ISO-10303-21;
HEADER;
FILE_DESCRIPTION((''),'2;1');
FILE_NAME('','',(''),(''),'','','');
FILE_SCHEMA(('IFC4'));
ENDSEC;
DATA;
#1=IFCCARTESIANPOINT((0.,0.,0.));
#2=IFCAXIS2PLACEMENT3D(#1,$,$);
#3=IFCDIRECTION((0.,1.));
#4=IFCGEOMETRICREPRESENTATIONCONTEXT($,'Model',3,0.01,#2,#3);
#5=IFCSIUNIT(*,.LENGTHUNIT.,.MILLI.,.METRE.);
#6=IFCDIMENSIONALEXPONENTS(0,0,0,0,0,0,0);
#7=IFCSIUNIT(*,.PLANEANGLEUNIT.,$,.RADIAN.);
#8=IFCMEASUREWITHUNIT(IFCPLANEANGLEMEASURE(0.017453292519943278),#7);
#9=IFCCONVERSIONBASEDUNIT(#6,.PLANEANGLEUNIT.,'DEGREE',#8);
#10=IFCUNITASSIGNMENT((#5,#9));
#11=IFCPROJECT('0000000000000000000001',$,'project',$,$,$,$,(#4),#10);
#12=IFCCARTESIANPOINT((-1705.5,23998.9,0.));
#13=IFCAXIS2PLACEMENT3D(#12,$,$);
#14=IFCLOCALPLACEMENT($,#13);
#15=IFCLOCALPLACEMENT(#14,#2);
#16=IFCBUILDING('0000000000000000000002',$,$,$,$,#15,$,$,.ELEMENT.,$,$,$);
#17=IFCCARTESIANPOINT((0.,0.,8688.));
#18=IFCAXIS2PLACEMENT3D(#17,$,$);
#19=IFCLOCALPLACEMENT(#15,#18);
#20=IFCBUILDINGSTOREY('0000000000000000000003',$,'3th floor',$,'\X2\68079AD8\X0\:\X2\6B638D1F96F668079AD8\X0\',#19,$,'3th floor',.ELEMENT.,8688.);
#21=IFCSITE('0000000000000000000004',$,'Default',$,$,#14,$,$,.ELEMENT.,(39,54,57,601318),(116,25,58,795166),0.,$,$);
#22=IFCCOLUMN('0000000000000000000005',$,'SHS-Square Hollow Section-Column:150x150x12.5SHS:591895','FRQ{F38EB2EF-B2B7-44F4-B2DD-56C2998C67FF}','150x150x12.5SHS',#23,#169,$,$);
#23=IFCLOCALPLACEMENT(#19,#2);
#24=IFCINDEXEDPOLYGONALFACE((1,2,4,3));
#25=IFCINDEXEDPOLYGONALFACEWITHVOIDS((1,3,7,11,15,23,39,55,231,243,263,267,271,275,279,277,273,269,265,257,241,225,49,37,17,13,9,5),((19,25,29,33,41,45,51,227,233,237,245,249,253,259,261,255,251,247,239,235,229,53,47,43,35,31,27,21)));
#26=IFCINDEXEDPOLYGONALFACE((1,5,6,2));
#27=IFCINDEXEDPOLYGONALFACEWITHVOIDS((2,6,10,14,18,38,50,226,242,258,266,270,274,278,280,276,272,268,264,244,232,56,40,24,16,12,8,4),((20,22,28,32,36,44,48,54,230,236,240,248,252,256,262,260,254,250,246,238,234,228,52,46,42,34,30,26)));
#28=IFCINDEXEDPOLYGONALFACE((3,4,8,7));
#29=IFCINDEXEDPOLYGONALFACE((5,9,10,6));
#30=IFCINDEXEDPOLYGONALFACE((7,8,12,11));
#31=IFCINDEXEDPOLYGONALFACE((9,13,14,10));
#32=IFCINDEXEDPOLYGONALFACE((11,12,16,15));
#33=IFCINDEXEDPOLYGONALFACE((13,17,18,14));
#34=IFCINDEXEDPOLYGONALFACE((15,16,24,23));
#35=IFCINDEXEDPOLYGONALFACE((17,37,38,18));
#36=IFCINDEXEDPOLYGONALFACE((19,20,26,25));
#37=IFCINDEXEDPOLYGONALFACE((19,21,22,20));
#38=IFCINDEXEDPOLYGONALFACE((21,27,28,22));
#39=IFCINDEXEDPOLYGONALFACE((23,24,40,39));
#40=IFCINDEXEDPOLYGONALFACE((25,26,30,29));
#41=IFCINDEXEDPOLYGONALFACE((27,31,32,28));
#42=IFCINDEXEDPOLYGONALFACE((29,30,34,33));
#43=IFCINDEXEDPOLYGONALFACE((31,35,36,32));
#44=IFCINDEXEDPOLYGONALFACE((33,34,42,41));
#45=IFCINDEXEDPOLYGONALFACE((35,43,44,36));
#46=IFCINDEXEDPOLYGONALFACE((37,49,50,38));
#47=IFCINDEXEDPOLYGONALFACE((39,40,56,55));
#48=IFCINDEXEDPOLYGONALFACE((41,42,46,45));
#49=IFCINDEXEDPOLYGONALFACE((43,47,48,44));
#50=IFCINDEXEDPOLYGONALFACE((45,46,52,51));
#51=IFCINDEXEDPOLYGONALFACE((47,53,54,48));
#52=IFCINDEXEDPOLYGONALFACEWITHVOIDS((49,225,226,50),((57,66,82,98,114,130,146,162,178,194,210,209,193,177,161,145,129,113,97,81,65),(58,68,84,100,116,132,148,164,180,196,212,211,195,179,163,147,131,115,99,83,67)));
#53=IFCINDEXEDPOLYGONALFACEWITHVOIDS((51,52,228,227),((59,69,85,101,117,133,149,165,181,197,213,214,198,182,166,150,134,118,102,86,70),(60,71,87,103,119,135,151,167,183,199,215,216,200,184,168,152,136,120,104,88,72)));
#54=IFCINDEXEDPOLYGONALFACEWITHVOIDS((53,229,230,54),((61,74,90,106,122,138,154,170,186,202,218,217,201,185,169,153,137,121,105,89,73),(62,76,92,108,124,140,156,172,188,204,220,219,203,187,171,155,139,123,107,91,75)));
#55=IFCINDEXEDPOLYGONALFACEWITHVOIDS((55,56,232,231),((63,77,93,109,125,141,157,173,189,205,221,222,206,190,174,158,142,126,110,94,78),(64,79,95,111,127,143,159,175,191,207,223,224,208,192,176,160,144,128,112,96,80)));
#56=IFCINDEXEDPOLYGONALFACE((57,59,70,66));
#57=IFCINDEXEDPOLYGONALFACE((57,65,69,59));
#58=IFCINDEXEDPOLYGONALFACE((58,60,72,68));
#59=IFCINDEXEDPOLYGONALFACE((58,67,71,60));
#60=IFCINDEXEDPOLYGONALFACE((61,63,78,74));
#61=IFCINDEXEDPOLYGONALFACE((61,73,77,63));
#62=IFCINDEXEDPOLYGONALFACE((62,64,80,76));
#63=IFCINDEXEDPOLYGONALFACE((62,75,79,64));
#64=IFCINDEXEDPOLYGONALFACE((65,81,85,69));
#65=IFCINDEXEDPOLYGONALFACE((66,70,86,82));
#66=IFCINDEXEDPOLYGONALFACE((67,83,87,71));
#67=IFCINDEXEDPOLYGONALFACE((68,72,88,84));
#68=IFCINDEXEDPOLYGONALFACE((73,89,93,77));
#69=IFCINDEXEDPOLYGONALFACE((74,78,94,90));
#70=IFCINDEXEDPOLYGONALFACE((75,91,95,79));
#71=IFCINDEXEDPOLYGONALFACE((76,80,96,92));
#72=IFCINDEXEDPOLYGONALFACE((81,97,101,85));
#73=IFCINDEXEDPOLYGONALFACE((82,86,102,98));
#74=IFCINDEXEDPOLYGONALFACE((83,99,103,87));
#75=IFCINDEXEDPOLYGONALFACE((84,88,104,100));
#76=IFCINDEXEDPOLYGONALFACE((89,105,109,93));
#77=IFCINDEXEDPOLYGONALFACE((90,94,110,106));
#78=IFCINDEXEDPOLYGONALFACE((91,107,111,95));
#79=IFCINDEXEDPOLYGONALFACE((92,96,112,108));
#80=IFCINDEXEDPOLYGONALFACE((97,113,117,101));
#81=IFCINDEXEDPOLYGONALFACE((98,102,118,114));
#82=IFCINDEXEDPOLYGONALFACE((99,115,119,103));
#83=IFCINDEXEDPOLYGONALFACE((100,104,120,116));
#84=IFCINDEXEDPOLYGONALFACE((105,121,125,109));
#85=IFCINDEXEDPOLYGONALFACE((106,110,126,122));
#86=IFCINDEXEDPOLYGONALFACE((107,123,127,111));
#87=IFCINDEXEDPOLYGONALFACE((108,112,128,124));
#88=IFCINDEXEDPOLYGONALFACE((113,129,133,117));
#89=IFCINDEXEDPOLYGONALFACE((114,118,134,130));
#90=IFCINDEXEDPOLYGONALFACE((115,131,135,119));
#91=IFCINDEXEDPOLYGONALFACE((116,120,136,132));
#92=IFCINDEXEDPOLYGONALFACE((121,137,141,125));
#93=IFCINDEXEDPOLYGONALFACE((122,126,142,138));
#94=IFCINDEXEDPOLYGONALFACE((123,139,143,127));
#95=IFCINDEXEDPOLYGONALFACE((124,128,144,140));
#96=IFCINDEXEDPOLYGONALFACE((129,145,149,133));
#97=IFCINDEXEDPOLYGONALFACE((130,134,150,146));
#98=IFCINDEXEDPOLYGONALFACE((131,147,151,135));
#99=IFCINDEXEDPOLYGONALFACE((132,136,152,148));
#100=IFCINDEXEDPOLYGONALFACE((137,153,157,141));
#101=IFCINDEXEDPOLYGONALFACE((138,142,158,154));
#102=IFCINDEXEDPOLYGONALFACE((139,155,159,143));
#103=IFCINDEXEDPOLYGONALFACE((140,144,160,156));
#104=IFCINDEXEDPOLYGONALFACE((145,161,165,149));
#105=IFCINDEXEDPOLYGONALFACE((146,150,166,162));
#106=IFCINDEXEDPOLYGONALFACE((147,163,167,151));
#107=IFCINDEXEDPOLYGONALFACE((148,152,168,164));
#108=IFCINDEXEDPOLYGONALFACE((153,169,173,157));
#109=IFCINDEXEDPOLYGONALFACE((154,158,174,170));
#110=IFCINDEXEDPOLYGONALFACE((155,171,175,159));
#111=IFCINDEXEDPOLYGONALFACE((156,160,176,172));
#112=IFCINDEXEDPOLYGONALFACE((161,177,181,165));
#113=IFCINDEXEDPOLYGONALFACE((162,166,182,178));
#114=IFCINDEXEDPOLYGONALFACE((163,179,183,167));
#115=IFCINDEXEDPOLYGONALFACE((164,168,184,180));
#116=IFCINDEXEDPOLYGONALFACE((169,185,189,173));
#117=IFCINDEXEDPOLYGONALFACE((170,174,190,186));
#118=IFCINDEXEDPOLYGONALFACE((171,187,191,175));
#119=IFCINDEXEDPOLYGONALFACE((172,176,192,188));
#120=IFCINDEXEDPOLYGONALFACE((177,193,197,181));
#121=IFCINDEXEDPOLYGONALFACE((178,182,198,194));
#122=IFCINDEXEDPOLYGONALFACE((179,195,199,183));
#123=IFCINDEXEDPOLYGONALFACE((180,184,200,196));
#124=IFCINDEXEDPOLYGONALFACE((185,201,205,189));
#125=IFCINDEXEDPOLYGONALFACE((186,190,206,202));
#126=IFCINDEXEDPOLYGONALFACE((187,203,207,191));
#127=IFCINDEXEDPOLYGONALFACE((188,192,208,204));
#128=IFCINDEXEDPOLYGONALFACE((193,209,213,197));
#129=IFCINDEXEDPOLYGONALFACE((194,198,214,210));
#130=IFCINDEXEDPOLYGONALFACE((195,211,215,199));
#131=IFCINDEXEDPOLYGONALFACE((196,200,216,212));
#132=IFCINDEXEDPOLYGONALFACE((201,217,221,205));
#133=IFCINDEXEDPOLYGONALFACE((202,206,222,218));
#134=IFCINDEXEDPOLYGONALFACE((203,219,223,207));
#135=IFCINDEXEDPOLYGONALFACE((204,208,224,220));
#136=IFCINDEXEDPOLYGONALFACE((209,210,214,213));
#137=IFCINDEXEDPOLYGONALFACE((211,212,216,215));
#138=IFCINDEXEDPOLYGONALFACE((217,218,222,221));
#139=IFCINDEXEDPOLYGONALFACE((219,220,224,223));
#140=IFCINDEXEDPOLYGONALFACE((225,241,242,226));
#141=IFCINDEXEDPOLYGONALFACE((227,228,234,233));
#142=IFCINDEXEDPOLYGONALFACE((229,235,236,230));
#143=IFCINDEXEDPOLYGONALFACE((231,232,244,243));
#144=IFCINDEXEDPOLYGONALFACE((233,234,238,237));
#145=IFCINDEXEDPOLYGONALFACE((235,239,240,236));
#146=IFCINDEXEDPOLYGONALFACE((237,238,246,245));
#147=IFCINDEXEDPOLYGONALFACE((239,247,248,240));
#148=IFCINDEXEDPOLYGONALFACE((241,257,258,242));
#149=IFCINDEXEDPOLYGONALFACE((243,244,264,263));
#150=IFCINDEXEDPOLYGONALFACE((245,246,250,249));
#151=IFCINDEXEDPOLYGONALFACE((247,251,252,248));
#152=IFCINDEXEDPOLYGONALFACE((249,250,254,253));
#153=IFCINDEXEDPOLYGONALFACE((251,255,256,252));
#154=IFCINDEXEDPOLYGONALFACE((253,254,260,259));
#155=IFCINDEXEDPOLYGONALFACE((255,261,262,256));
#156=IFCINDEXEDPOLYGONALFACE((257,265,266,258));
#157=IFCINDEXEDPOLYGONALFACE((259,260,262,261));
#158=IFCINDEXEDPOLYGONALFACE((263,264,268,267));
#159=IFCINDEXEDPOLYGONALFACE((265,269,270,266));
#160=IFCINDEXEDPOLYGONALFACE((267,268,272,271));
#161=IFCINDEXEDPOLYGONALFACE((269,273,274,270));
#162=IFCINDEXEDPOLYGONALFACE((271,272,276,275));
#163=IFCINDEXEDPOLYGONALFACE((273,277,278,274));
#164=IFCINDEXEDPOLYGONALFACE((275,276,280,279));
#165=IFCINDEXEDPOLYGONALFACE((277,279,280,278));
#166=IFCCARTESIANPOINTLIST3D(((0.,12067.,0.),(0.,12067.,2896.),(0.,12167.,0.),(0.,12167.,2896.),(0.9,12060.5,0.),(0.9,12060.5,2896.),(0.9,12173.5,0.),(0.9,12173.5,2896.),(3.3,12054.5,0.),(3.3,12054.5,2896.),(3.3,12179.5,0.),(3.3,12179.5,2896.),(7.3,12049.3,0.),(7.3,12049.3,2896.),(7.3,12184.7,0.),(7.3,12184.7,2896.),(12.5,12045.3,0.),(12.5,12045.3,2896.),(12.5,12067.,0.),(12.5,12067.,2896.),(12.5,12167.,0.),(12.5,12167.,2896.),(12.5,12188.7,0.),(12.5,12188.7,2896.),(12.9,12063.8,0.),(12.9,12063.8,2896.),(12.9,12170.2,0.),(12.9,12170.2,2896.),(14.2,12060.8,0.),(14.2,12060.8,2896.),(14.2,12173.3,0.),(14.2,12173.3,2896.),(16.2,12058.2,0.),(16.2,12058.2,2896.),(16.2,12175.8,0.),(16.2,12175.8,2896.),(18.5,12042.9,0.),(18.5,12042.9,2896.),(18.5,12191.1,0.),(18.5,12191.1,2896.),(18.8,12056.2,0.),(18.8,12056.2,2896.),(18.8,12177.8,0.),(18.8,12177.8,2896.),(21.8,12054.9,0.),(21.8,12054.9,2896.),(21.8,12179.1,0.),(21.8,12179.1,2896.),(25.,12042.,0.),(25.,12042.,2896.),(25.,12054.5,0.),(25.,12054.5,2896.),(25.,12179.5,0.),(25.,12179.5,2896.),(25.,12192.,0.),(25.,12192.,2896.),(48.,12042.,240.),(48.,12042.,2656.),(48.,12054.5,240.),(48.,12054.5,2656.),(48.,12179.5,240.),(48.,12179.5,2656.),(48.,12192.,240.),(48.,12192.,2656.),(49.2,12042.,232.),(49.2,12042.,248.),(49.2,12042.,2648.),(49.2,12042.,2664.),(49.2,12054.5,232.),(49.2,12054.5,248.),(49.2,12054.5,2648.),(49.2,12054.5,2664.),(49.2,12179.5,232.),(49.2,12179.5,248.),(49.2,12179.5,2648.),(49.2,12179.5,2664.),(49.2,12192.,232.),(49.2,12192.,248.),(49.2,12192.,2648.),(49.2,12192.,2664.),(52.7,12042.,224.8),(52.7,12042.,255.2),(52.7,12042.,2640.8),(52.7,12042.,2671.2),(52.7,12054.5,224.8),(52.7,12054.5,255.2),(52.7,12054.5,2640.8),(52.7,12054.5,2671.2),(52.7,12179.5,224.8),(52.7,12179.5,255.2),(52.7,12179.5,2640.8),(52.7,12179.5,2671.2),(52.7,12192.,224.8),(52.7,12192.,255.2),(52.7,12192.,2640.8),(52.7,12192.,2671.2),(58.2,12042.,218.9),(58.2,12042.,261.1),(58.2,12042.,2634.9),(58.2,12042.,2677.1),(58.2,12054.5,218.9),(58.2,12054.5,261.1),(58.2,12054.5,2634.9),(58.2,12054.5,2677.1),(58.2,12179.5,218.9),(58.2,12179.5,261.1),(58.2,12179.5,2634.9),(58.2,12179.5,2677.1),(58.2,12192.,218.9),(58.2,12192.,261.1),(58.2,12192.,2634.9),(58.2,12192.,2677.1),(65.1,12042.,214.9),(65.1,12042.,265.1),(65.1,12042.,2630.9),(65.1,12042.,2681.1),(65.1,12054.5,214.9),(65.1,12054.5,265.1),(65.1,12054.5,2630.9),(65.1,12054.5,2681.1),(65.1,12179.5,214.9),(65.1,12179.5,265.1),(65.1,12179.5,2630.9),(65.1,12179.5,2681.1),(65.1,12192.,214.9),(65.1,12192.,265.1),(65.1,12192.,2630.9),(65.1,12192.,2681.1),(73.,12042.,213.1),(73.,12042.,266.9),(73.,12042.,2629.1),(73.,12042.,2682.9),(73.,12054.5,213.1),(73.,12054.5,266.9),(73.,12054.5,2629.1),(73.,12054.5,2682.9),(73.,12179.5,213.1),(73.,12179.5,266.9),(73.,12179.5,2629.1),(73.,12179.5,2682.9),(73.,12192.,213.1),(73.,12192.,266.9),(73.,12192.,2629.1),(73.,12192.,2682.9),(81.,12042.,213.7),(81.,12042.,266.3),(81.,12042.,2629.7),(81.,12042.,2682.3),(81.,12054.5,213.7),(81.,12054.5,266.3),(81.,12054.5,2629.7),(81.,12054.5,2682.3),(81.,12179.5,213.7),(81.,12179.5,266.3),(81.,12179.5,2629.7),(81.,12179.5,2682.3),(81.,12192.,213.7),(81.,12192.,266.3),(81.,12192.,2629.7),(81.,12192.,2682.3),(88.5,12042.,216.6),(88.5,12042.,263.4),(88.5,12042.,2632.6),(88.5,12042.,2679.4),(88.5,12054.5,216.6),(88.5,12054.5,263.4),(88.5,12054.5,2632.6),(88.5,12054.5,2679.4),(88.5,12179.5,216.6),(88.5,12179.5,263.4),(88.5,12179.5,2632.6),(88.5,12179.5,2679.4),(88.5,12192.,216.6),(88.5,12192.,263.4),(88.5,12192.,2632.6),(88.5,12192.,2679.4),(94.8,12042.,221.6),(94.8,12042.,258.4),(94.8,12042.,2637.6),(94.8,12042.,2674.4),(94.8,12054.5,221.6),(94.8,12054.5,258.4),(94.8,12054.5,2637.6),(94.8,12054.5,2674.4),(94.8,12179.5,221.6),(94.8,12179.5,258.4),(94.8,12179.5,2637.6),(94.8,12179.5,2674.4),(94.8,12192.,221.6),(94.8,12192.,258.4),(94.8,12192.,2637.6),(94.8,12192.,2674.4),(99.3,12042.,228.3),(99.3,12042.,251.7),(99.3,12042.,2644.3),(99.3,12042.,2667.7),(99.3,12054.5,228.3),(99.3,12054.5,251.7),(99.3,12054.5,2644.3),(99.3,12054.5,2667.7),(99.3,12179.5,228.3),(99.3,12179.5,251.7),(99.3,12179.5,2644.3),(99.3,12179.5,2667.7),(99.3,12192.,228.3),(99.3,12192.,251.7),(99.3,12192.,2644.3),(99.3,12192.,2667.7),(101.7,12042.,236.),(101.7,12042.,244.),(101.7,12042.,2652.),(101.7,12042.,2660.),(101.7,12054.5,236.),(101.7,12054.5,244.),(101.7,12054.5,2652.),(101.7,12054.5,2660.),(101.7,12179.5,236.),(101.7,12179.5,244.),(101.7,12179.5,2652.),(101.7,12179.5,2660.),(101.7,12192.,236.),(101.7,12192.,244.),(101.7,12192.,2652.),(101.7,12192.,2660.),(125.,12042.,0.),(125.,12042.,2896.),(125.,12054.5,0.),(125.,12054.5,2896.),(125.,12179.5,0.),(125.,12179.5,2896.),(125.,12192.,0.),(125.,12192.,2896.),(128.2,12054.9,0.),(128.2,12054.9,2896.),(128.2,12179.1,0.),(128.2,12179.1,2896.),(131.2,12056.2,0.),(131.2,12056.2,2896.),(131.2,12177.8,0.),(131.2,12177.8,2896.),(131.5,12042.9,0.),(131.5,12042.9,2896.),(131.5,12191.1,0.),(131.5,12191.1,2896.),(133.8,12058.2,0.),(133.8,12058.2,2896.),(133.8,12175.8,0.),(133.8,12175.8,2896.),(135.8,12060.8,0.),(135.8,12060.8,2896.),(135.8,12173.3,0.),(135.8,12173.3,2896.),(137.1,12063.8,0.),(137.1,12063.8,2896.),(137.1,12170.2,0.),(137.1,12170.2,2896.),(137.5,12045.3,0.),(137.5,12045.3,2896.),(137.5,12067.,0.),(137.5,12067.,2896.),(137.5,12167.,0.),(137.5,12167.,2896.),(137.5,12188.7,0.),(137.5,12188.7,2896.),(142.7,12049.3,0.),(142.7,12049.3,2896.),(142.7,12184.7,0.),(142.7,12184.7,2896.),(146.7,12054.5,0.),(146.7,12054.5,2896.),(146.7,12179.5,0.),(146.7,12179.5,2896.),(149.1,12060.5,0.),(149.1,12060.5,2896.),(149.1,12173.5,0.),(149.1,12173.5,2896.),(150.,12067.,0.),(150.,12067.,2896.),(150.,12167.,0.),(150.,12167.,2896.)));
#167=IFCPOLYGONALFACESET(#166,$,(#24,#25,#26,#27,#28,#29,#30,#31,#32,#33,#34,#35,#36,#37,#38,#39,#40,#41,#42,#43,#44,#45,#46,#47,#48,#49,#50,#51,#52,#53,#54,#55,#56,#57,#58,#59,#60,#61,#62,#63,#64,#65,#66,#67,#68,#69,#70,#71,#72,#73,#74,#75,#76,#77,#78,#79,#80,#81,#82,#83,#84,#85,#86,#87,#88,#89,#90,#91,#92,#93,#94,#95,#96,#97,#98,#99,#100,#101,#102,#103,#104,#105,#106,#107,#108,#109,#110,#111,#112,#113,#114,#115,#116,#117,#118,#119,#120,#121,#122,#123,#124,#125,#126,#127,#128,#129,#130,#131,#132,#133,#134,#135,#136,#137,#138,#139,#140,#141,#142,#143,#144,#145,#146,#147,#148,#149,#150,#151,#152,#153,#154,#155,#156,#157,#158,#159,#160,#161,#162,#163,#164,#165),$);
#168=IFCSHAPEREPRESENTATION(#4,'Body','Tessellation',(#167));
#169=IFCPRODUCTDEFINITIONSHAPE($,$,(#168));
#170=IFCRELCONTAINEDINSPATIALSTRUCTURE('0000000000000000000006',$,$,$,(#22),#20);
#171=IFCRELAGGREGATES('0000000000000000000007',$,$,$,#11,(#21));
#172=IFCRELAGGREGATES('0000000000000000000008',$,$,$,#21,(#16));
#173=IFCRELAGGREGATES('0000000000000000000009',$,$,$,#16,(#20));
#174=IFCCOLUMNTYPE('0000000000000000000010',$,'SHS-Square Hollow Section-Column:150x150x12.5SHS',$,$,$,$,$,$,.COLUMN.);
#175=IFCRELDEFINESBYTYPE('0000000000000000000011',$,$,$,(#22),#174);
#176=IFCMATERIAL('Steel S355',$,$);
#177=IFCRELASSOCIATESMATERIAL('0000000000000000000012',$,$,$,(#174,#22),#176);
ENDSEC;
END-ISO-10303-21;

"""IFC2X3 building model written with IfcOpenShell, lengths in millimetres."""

from ifc_helpers import new_model, entity, si_unit, converted_unit, direction, frame, frame_2d, origin, origin_2d, place, context, project, spatial, circle_curve, hollow_rectangle, outline, extrude, material, type_object, element, save


model = new_model("IFC2X3")

# Units and contexts
model_context = context("Model", 3, precision=0.01, world=origin(), true_north=direction((0.0, 1.0)))
ifc_project = project(units=[si_unit("LENGTHUNIT", "METRE", prefix="MILLI"), converted_unit("PLANEANGLEUNIT", "DEGREE", entity("IfcPlaneAngleMeasure", 0.017453292519943278), si_unit("PLANEANGLEUNIT", "RADIAN"), dimensions=[0, 0, 0, 0, 0, 0, 0])], contexts=[model_context])

# Site, building, storey
site_placement = place(None, frame((-1705.5, 23998.9, 0.0)))
site = spatial("IfcSite", under=ifc_project, at=site_placement, Name="Default", CompositionType="ELEMENT", RefLatitude=(39, 54, 57, 601318), RefLongitude=(116, 25, 58, 795166), RefElevation=0.0)
building_placement = place(site_placement, origin())
building = spatial("IfcBuilding", under=site, at=building_placement, CompositionType="ELEMENT")
storey_placement = place(building_placement, frame((0.0, 0.0, 8688.0)))
storey = spatial("IfcBuildingStorey", under=building, at=storey_placement, Name="3th floor", ObjectType="标高:正负零标高", LongName="3th floor", CompositionType="ELEMENT", Elevation=8688.0)

# Column, openings
ifc_material_1 = material(Name="Steel S355")
column_type_1 = type_object("IfcColumnType", Name="SHS-Square Hollow Section-Column:150x150x12.5SHS", PredefinedType="COLUMN", material=ifc_material_1)
column_1_placement = place(storey_placement, frame((75.0, 12117.0, 2896.0), z_axis=(0.0, 0.0, 1.0), x_axis=(0.0, -1.0, 0.0)))
column_1 = element("IfcColumn", 1, at=column_1_placement, inside=storey, type_object=column_type_1, material=ifc_material_1, Name="SHS-Square Hollow Section-Column:150x150x12.5SHS:591895", Description="FRQ{F38EB2EF-B2B7-44F4-B2DD-56C2998C67FF}", ObjectType="150x150x12.5SHS", context=model_context, shape_type="SweptSolid", body=[
    extrude(hollow_rectangle(XDim=150.0, YDim=150.0, WallThickness=12.5, InnerFilletRadius=12.5, OuterFilletRadius=25.0, at=origin_2d()), origin(), (0.0, 0.0, -1.0), 2896.0),
])
opening_1_placement = place(column_1_placement, frame((175.1, 0.0, -2896.0), z_axis=(-1.0, 0.0, 0.0), x_axis=(0.0, -1.0, 0.0)))
element("IfcOpeningElement", 2, at=opening_1_placement, cuts=column_1, ObjectType="Opening", context=model_context, shape_type="SweptSolid", body=[
    extrude(outline(circle_curve(frame_2d((0.0, 240.0), x_axis=(1.0, 0.0)), 27.0)), origin(), (0.0, 0.0, 1.0), 350.2),
])
opening_2_placement = place(column_1_placement, frame((175.1, 0.0, 0.0), z_axis=(-1.0, 0.0, 0.0), x_axis=(0.0, -1.0, 0.0)))
element("IfcOpeningElement", 3, at=opening_2_placement, cuts=column_1, ObjectType="Opening", context=model_context, shape_type="SweptSolid", body=[
    extrude(outline(circle_curve(frame_2d((0.0, -240.0), x_axis=(1.0, 0.0)), 27.0)), origin(), (0.0, 0.0, 1.0), 350.2),
])

save(model, "model.ifc")
